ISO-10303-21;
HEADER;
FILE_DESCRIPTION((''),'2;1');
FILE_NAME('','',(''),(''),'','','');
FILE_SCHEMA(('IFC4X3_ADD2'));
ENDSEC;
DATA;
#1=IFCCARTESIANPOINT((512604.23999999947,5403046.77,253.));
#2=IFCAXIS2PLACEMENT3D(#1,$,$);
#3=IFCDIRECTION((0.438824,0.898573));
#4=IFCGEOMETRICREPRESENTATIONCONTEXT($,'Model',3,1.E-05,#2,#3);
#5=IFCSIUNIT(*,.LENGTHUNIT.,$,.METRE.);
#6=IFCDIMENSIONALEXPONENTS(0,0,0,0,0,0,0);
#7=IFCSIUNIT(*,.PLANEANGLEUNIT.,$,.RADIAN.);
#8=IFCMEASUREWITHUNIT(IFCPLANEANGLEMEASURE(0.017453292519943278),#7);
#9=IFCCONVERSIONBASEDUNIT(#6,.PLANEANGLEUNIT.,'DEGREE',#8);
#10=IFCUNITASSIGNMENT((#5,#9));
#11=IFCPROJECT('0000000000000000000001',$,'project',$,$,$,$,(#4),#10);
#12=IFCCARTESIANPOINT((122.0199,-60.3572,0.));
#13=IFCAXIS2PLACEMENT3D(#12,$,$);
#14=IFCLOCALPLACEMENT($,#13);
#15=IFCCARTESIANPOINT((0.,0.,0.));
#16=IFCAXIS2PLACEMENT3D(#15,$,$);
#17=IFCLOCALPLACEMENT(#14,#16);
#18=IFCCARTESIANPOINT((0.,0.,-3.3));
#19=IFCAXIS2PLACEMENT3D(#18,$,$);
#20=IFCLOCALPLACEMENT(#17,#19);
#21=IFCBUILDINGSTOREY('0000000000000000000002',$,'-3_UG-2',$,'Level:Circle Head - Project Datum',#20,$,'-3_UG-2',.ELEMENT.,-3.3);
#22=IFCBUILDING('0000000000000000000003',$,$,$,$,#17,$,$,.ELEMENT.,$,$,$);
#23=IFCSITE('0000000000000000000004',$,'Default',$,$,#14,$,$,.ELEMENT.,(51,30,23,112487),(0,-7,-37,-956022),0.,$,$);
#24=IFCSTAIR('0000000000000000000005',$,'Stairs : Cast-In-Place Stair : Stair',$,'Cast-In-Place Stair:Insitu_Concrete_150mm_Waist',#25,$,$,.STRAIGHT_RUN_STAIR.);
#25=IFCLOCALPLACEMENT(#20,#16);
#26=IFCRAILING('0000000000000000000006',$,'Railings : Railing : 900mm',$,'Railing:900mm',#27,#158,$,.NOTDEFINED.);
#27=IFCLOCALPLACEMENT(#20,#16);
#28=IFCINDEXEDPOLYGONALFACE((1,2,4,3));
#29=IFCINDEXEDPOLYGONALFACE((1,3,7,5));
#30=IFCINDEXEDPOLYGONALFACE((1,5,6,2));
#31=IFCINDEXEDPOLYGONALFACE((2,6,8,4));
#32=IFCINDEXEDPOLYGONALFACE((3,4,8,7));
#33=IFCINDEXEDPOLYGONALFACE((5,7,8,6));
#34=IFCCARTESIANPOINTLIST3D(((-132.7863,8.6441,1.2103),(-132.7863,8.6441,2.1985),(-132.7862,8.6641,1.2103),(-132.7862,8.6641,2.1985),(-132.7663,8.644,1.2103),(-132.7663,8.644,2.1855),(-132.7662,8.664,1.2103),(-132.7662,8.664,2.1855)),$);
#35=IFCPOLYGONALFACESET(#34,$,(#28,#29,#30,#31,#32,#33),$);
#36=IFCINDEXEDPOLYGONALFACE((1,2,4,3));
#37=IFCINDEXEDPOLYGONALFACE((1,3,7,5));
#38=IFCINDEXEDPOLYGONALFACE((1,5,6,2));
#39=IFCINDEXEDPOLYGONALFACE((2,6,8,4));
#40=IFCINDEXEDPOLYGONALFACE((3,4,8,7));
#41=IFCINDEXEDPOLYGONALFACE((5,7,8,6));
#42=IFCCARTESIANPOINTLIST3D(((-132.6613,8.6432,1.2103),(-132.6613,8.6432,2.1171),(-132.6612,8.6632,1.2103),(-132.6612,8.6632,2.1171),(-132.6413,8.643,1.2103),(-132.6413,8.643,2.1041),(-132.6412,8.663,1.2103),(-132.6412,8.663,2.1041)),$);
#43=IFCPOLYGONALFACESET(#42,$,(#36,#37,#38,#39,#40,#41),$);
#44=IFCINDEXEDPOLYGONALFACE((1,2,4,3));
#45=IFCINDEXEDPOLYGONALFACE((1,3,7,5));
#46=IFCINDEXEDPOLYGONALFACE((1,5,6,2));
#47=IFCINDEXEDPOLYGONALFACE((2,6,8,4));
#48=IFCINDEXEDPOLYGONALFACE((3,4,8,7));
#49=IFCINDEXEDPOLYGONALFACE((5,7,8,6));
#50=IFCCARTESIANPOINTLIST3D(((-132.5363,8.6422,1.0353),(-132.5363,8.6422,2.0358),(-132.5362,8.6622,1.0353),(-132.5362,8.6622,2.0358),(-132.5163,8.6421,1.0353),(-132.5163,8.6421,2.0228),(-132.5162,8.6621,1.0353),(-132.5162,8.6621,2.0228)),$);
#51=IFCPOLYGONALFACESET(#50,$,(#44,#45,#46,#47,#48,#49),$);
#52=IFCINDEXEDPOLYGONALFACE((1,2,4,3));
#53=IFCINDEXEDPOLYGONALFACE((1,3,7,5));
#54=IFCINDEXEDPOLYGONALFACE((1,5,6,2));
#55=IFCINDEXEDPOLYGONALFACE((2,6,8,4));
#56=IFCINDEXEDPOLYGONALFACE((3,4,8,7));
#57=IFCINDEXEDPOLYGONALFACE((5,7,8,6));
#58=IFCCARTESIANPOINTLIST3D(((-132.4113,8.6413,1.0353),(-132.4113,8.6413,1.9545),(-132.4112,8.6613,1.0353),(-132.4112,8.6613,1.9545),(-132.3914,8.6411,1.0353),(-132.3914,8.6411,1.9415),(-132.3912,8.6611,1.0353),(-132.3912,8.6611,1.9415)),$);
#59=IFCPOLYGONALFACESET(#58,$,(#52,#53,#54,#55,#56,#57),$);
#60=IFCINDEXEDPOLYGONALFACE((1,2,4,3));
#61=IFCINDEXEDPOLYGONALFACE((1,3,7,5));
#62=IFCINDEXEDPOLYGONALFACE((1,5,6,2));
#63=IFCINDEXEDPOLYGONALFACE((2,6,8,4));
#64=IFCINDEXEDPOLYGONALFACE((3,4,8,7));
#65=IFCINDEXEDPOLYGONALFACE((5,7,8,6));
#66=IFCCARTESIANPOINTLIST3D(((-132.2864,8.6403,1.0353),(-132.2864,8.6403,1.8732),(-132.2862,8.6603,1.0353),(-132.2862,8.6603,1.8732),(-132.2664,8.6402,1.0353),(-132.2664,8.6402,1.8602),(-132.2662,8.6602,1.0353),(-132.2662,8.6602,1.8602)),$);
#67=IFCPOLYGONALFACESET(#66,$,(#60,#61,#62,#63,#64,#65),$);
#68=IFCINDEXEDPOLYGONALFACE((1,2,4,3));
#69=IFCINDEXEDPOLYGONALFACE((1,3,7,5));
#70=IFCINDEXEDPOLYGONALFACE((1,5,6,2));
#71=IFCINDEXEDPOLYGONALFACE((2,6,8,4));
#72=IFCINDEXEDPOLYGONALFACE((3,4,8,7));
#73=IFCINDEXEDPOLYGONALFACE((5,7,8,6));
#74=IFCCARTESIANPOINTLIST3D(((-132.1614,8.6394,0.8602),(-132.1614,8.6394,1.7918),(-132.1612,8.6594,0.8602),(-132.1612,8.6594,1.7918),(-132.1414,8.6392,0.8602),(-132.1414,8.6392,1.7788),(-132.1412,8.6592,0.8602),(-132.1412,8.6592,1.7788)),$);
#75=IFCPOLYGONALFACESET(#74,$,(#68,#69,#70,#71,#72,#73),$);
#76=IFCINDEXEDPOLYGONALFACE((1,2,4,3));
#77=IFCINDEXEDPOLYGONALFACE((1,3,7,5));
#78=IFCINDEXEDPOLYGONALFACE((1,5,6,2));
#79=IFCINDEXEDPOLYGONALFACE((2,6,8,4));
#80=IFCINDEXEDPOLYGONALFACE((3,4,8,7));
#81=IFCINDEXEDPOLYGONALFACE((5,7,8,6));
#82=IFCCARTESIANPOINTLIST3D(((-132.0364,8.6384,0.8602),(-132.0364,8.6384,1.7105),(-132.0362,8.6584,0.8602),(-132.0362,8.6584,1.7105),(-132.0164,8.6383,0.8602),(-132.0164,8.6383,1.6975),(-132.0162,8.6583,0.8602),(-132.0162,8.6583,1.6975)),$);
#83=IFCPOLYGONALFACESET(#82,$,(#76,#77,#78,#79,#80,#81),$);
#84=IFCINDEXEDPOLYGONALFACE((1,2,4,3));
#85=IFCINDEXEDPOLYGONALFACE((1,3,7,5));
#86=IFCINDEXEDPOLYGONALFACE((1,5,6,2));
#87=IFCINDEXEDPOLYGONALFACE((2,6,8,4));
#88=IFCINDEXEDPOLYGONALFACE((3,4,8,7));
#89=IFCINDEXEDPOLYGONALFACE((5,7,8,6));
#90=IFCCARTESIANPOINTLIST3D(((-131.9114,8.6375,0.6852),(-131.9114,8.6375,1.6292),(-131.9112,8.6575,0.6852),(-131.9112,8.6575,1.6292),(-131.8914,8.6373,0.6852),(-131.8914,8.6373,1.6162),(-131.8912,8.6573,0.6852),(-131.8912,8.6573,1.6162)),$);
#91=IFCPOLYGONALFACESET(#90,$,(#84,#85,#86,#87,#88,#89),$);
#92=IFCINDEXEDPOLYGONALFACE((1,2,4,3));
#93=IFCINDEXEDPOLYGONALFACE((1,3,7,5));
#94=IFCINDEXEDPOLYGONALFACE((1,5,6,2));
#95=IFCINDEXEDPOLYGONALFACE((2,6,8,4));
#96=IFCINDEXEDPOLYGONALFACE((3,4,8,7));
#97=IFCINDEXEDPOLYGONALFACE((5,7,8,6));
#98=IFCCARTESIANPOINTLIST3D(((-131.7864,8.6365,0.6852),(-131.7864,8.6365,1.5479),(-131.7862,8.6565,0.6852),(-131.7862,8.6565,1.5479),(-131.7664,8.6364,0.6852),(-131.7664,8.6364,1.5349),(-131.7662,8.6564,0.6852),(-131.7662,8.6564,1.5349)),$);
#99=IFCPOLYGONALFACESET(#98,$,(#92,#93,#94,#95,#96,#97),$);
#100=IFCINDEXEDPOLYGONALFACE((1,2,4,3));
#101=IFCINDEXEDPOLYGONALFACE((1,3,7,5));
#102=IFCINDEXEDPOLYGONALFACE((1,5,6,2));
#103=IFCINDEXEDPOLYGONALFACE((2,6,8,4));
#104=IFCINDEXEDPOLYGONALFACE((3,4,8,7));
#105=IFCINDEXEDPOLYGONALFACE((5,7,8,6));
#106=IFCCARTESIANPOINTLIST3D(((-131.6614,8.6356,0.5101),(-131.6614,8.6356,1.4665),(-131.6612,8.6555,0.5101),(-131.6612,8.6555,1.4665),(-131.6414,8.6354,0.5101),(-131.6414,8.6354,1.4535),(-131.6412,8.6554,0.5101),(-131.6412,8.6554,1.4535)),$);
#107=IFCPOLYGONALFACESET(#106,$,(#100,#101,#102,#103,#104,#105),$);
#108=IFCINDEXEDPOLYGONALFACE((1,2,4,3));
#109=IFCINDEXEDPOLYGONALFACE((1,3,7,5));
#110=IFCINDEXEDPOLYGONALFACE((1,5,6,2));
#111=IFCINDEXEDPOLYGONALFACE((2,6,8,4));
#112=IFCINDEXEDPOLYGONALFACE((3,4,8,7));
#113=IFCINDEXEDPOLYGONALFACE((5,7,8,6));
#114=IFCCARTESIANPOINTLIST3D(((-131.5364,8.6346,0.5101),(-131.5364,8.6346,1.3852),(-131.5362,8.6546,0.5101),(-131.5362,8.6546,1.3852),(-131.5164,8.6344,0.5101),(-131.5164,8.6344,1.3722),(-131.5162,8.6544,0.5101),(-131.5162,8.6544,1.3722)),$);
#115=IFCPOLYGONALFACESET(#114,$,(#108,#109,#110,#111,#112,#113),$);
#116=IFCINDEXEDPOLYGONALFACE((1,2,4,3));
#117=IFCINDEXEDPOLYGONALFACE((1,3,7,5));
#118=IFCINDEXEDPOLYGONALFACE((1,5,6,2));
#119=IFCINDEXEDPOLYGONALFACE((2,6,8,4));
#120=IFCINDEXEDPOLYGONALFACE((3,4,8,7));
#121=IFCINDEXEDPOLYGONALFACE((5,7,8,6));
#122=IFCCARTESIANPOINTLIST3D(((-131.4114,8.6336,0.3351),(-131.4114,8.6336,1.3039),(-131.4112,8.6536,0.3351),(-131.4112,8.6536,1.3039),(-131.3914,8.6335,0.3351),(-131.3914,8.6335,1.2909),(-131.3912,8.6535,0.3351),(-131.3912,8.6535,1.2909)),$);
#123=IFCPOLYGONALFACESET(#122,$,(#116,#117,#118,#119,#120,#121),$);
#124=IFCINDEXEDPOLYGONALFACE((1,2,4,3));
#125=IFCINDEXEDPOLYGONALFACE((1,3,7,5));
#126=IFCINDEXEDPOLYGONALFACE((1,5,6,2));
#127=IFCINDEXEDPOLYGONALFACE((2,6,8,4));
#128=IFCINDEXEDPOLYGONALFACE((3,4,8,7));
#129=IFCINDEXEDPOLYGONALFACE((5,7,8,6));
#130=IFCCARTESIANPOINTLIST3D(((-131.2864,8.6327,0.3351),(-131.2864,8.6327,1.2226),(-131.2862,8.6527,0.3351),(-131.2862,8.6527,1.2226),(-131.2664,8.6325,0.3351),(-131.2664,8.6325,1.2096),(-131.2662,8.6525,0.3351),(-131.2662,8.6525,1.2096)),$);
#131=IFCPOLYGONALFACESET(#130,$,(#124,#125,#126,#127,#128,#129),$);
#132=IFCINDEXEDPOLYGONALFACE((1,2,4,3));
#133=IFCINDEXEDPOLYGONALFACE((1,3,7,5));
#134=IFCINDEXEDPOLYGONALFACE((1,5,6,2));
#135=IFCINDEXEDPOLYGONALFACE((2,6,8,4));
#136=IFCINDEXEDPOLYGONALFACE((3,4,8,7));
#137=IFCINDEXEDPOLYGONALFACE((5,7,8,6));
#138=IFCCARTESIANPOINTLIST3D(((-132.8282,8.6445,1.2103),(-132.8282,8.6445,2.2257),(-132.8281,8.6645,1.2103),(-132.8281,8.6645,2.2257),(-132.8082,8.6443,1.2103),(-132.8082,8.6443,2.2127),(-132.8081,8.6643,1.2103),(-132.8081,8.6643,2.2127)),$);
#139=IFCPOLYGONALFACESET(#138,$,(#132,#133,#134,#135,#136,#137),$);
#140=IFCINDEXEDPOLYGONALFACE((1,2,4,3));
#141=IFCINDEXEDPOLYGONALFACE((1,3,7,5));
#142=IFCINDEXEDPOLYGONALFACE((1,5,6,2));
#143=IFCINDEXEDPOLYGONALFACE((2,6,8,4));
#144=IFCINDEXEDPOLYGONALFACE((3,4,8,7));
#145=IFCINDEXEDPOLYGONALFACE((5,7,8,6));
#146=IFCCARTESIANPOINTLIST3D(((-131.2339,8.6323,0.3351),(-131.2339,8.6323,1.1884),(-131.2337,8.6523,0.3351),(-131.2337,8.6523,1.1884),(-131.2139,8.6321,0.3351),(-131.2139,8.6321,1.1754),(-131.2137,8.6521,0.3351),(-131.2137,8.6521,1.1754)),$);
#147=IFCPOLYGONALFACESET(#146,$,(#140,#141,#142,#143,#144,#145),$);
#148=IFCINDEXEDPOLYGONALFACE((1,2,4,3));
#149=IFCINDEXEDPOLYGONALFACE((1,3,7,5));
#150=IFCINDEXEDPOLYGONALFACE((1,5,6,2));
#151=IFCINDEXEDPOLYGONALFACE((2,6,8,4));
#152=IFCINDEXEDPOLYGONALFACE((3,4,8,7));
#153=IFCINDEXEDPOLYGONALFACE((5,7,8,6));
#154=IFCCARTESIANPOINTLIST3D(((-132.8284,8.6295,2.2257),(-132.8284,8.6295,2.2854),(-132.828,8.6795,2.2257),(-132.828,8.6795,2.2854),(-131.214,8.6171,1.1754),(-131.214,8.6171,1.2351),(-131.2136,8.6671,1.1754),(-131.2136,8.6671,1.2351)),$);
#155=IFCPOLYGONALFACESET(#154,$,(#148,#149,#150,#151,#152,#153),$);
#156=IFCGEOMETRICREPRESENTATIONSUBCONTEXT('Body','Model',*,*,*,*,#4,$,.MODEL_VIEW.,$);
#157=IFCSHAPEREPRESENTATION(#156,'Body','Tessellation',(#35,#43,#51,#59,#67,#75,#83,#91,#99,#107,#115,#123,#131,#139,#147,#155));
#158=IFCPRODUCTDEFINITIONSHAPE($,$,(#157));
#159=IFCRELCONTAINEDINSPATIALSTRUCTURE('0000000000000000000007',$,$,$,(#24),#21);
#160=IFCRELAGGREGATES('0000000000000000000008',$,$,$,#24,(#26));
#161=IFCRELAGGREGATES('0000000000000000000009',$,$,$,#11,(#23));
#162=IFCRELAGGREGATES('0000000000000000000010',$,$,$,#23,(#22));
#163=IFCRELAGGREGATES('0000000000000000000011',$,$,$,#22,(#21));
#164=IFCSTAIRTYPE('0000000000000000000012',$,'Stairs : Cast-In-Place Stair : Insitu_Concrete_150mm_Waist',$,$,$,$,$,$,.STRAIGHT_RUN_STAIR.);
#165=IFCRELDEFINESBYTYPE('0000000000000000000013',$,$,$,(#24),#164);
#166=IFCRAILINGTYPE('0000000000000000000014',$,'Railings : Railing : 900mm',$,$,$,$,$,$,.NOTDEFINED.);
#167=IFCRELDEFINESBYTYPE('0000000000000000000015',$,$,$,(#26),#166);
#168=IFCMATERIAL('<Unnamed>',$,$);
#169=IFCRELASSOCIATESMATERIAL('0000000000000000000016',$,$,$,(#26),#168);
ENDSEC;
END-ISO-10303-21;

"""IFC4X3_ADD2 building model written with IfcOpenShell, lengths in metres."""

from ifc_helpers import new_model, entity, si_unit, converted_unit, direction, frame, origin, place, context, subcontext, project, spatial, polyline, outline, extrude, material, type_object, element, aggregate, save


model = new_model("IFC4X3_ADD2")

# Units and contexts
model_context = context("Model", 3, precision=1e-05, world=frame((512604.23999999947, 5403046.77, 253.0)), true_north=direction((0.438824, 0.898573)))
body_context = subcontext(model_context, "Body", "Model", "MODEL_VIEW")
ifc_project = project(units=[si_unit("LENGTHUNIT", "METRE"), converted_unit("PLANEANGLEUNIT", "DEGREE", entity("IfcPlaneAngleMeasure", 0.017453292519943278), si_unit("PLANEANGLEUNIT", "RADIAN"), dimensions=[0, 0, 0, 0, 0, 0, 0])], contexts=[model_context])

# Site, building, storey
site_placement = place(None, frame((122.0199, -60.3572, 0.0)))
site = spatial("IfcSite", under=ifc_project, at=site_placement, Name="Default", CompositionType="ELEMENT", RefLatitude=(51, 30, 23, 112487), RefLongitude=(0, -7, -37, -956022), RefElevation=0.0)
building_placement = place(site_placement, origin())
building = spatial("IfcBuilding", under=site, at=building_placement, CompositionType="ELEMENT")
storey_placement = place(building_placement, frame((0.0, 0.0, -3.3)))
storey = spatial("IfcBuildingStorey", under=building, at=storey_placement, Name="-3_UG-2", ObjectType="Level:Circle Head - Project Datum", LongName="-3_UG-2", CompositionType="ELEMENT", Elevation=-3.3)

# Stair, railing
stair_type = type_object("IfcStairType", Name="Stairs : Cast-In-Place Stair : Insitu_Concrete_150mm_Waist", PredefinedType="STRAIGHT_RUN_STAIR")
stair_placement = place(storey_placement, origin())
stair = element("IfcStair", 1, at=stair_placement, inside=storey, type_object=stair_type, Name="Stairs : Cast-In-Place Stair : Stair", ObjectType="Cast-In-Place Stair:Insitu_Concrete_150mm_Waist", PredefinedType="STRAIGHT_RUN_STAIR")
ifc_material_1 = material(Name="<Unnamed>")
railing_type = type_object("IfcRailingType", Name="Railings : Railing : 900mm", PredefinedType="NOTDEFINED")
railing_1_placement = place(stair_placement, frame((-132.8284, 8.6171, 0.3351)))
railing_1 = element("IfcRailing", 2, at=railing_1_placement, type_object=railing_type, material=ifc_material_1, Name="Railings : Railing : 900mm", ObjectType="Railing:900mm", PredefinedType="NOTDEFINED", context=body_context, shape_type="SweptSolid", body=[
    extrude(outline(polyline([(-0.01, -0.4908), (0.01, -0.4908), (0.01, 0.4973), (-0.01, 0.4843), (-0.01, -0.4908)])), frame((0.052, 0.0269, 1.3661), z_axis=(0.007629, 0.999971, 0.0), x_axis=(-0.999971, 0.007629, 0.0)), (0.0, 0.0, 1.0), 0.02),
    extrude(outline(polyline([(-0.01, -0.4502), (0.01, -0.4502), (0.01, 0.4567), (-0.01, 0.4436), (-0.01, -0.4502)])), frame((0.177, 0.026, 1.3254), z_axis=(0.007629, 0.999971, 0.0), x_axis=(-0.999971, 0.007629, 0.0)), (0.0, 0.0, 1.0), 0.02),
    extrude(outline(polyline([(-0.01, -0.497), (0.01, -0.497), (0.01, 0.5035), (-0.01, 0.4905), (-0.01, -0.497)])), frame((0.302, 0.025, 1.1972), z_axis=(0.007629, 0.999971, 0.0), x_axis=(-0.999971, 0.007629, 0.0)), (0.0, 0.0, 1.0), 0.02),
    extrude(outline(polyline([(-0.01, -0.4564), (0.01, -0.4564), (0.01, 0.4629), (-0.01, 0.4499), (-0.01, -0.4564)])), frame((0.427, 0.0241, 1.1566), z_axis=(0.007629, 0.999971, 0.0), x_axis=(-0.999971, 0.007629, 0.0)), (0.0, 0.0, 1.0), 0.02),
    extrude(outline(polyline([(-0.01, -0.4157), (0.01, -0.4157), (0.01, 0.4222), (-0.01, 0.4092), (-0.01, -0.4157)])), frame((0.552, 0.0231, 1.1159), z_axis=(0.007629, 0.999971, 0.0), x_axis=(-0.999971, 0.007629, 0.0)), (0.0, 0.0, 1.0), 0.02),
    extrude(outline(polyline([(-0.01, -0.4626), (0.01, -0.4626), (0.01, 0.4691), (-0.01, 0.4561), (-0.01, -0.4626)])), frame((0.677, 0.0222, 0.9877), z_axis=(0.007629, 0.999971, 0.0), x_axis=(-0.999971, 0.007629, 0.0)), (0.0, 0.0, 1.0), 0.02),
    extrude(outline(polyline([(-0.01, -0.4219), (0.01, -0.4219), (0.01, 0.4284), (-0.01, 0.4154), (-0.01, -0.4219)])), frame((0.802, 0.0212, 0.9471), z_axis=(0.007629, 0.999971, 0.0), x_axis=(-0.999971, 0.007629, 0.0)), (0.0, 0.0, 1.0), 0.02),
    extrude(outline(polyline([(-0.01, -0.4688), (0.01, -0.4688), (0.01, 0.4753), (-0.01, 0.4623), (-0.01, -0.4688)])), frame((0.927, 0.0202, 0.8189), z_axis=(0.007629, 0.999971, 0.0), x_axis=(-0.999971, 0.007629, 0.0)), (0.0, 0.0, 1.0), 0.02),
    extrude(outline(polyline([(-0.01, -0.4281), (0.01, -0.4281), (0.01, 0.4346), (-0.01, 0.4216), (-0.01, -0.4281)])), frame((1.052, 0.0193, 0.7782), z_axis=(0.007629, 0.999971, 0.0), x_axis=(-0.999971, 0.007629, 0.0)), (0.0, 0.0, 1.0), 0.02),
    extrude(outline(polyline([(-0.01, -0.475), (0.01, -0.475), (0.01, 0.4815), (-0.01, 0.4685), (-0.01, -0.475)])), frame((1.177, 0.0183, 0.65), z_axis=(0.007629, 0.999971, 0.0), x_axis=(-0.999971, 0.007629, 0.0)), (0.0, 0.0, 1.0), 0.02),
    extrude(outline(polyline([(-0.01, -0.4343), (0.01, -0.4343), (0.01, 0.4408), (-0.01, 0.4278), (-0.01, -0.4343)])), frame((1.302, 0.0174, 0.6094), z_axis=(0.007629, 0.999971, 0.0), x_axis=(-0.999971, 0.007629, 0.0)), (0.0, 0.0, 1.0), 0.02),
    extrude(outline(polyline([(-0.01, -0.4812), (0.01, -0.4812), (0.01, 0.4877), (-0.01, 0.4747), (-0.01, -0.4812)])), frame((1.427, 0.0164, 0.4812), z_axis=(0.007629, 0.999971, 0.0), x_axis=(-0.999971, 0.007629, 0.0)), (0.0, 0.0, 1.0), 0.02),
    extrude(outline(polyline([(-0.01, -0.4405), (0.01, -0.4405), (0.01, 0.447), (-0.01, 0.434), (-0.01, -0.4405)])), frame((1.552, 0.0155, 0.4405), z_axis=(0.007629, 0.999971, 0.0), x_axis=(-0.999971, 0.007629, 0.0)), (0.0, 0.0, 1.0), 0.02),
    extrude(outline(polyline([(-0.01, -0.5044), (0.01, -0.5044), (0.01, 0.511), (-0.01, 0.4979), (-0.01, -0.5044)])), frame((0.0101, 0.0272, 1.3797), z_axis=(0.007629, 0.999971, 0.0), x_axis=(-0.999971, 0.007629, 0.0)), (0.0, 0.0, 1.0), 0.02),
    extrude(outline(polyline([(-0.01, -0.4234), (0.01, -0.4234), (0.01, 0.4299), (-0.01, 0.4169), (-0.01, -0.4234)])), frame((1.6045, 0.0151, 0.4234), z_axis=(0.007629, 0.999971, 0.0), x_axis=(-0.999971, 0.007629, 0.0)), (0.0, 0.0, 1.0), 0.02),
    extrude(outline(polyline([(-0.9793, -0.025), (0.9467, -0.025), (0.9793, 0.025), (-0.9467, 0.025), (-0.9793, -0.025)])), frame((0.8072, 0.0062, 1.3953), z_axis=(0.007629, 0.999971, 0.0), x_axis=(-0.838192, 0.006395, 0.545338)), (0.0, 0.0, 1.0), 0.05),
])
aggregate(stair, [railing_1])

save(model, "model.ifc")
